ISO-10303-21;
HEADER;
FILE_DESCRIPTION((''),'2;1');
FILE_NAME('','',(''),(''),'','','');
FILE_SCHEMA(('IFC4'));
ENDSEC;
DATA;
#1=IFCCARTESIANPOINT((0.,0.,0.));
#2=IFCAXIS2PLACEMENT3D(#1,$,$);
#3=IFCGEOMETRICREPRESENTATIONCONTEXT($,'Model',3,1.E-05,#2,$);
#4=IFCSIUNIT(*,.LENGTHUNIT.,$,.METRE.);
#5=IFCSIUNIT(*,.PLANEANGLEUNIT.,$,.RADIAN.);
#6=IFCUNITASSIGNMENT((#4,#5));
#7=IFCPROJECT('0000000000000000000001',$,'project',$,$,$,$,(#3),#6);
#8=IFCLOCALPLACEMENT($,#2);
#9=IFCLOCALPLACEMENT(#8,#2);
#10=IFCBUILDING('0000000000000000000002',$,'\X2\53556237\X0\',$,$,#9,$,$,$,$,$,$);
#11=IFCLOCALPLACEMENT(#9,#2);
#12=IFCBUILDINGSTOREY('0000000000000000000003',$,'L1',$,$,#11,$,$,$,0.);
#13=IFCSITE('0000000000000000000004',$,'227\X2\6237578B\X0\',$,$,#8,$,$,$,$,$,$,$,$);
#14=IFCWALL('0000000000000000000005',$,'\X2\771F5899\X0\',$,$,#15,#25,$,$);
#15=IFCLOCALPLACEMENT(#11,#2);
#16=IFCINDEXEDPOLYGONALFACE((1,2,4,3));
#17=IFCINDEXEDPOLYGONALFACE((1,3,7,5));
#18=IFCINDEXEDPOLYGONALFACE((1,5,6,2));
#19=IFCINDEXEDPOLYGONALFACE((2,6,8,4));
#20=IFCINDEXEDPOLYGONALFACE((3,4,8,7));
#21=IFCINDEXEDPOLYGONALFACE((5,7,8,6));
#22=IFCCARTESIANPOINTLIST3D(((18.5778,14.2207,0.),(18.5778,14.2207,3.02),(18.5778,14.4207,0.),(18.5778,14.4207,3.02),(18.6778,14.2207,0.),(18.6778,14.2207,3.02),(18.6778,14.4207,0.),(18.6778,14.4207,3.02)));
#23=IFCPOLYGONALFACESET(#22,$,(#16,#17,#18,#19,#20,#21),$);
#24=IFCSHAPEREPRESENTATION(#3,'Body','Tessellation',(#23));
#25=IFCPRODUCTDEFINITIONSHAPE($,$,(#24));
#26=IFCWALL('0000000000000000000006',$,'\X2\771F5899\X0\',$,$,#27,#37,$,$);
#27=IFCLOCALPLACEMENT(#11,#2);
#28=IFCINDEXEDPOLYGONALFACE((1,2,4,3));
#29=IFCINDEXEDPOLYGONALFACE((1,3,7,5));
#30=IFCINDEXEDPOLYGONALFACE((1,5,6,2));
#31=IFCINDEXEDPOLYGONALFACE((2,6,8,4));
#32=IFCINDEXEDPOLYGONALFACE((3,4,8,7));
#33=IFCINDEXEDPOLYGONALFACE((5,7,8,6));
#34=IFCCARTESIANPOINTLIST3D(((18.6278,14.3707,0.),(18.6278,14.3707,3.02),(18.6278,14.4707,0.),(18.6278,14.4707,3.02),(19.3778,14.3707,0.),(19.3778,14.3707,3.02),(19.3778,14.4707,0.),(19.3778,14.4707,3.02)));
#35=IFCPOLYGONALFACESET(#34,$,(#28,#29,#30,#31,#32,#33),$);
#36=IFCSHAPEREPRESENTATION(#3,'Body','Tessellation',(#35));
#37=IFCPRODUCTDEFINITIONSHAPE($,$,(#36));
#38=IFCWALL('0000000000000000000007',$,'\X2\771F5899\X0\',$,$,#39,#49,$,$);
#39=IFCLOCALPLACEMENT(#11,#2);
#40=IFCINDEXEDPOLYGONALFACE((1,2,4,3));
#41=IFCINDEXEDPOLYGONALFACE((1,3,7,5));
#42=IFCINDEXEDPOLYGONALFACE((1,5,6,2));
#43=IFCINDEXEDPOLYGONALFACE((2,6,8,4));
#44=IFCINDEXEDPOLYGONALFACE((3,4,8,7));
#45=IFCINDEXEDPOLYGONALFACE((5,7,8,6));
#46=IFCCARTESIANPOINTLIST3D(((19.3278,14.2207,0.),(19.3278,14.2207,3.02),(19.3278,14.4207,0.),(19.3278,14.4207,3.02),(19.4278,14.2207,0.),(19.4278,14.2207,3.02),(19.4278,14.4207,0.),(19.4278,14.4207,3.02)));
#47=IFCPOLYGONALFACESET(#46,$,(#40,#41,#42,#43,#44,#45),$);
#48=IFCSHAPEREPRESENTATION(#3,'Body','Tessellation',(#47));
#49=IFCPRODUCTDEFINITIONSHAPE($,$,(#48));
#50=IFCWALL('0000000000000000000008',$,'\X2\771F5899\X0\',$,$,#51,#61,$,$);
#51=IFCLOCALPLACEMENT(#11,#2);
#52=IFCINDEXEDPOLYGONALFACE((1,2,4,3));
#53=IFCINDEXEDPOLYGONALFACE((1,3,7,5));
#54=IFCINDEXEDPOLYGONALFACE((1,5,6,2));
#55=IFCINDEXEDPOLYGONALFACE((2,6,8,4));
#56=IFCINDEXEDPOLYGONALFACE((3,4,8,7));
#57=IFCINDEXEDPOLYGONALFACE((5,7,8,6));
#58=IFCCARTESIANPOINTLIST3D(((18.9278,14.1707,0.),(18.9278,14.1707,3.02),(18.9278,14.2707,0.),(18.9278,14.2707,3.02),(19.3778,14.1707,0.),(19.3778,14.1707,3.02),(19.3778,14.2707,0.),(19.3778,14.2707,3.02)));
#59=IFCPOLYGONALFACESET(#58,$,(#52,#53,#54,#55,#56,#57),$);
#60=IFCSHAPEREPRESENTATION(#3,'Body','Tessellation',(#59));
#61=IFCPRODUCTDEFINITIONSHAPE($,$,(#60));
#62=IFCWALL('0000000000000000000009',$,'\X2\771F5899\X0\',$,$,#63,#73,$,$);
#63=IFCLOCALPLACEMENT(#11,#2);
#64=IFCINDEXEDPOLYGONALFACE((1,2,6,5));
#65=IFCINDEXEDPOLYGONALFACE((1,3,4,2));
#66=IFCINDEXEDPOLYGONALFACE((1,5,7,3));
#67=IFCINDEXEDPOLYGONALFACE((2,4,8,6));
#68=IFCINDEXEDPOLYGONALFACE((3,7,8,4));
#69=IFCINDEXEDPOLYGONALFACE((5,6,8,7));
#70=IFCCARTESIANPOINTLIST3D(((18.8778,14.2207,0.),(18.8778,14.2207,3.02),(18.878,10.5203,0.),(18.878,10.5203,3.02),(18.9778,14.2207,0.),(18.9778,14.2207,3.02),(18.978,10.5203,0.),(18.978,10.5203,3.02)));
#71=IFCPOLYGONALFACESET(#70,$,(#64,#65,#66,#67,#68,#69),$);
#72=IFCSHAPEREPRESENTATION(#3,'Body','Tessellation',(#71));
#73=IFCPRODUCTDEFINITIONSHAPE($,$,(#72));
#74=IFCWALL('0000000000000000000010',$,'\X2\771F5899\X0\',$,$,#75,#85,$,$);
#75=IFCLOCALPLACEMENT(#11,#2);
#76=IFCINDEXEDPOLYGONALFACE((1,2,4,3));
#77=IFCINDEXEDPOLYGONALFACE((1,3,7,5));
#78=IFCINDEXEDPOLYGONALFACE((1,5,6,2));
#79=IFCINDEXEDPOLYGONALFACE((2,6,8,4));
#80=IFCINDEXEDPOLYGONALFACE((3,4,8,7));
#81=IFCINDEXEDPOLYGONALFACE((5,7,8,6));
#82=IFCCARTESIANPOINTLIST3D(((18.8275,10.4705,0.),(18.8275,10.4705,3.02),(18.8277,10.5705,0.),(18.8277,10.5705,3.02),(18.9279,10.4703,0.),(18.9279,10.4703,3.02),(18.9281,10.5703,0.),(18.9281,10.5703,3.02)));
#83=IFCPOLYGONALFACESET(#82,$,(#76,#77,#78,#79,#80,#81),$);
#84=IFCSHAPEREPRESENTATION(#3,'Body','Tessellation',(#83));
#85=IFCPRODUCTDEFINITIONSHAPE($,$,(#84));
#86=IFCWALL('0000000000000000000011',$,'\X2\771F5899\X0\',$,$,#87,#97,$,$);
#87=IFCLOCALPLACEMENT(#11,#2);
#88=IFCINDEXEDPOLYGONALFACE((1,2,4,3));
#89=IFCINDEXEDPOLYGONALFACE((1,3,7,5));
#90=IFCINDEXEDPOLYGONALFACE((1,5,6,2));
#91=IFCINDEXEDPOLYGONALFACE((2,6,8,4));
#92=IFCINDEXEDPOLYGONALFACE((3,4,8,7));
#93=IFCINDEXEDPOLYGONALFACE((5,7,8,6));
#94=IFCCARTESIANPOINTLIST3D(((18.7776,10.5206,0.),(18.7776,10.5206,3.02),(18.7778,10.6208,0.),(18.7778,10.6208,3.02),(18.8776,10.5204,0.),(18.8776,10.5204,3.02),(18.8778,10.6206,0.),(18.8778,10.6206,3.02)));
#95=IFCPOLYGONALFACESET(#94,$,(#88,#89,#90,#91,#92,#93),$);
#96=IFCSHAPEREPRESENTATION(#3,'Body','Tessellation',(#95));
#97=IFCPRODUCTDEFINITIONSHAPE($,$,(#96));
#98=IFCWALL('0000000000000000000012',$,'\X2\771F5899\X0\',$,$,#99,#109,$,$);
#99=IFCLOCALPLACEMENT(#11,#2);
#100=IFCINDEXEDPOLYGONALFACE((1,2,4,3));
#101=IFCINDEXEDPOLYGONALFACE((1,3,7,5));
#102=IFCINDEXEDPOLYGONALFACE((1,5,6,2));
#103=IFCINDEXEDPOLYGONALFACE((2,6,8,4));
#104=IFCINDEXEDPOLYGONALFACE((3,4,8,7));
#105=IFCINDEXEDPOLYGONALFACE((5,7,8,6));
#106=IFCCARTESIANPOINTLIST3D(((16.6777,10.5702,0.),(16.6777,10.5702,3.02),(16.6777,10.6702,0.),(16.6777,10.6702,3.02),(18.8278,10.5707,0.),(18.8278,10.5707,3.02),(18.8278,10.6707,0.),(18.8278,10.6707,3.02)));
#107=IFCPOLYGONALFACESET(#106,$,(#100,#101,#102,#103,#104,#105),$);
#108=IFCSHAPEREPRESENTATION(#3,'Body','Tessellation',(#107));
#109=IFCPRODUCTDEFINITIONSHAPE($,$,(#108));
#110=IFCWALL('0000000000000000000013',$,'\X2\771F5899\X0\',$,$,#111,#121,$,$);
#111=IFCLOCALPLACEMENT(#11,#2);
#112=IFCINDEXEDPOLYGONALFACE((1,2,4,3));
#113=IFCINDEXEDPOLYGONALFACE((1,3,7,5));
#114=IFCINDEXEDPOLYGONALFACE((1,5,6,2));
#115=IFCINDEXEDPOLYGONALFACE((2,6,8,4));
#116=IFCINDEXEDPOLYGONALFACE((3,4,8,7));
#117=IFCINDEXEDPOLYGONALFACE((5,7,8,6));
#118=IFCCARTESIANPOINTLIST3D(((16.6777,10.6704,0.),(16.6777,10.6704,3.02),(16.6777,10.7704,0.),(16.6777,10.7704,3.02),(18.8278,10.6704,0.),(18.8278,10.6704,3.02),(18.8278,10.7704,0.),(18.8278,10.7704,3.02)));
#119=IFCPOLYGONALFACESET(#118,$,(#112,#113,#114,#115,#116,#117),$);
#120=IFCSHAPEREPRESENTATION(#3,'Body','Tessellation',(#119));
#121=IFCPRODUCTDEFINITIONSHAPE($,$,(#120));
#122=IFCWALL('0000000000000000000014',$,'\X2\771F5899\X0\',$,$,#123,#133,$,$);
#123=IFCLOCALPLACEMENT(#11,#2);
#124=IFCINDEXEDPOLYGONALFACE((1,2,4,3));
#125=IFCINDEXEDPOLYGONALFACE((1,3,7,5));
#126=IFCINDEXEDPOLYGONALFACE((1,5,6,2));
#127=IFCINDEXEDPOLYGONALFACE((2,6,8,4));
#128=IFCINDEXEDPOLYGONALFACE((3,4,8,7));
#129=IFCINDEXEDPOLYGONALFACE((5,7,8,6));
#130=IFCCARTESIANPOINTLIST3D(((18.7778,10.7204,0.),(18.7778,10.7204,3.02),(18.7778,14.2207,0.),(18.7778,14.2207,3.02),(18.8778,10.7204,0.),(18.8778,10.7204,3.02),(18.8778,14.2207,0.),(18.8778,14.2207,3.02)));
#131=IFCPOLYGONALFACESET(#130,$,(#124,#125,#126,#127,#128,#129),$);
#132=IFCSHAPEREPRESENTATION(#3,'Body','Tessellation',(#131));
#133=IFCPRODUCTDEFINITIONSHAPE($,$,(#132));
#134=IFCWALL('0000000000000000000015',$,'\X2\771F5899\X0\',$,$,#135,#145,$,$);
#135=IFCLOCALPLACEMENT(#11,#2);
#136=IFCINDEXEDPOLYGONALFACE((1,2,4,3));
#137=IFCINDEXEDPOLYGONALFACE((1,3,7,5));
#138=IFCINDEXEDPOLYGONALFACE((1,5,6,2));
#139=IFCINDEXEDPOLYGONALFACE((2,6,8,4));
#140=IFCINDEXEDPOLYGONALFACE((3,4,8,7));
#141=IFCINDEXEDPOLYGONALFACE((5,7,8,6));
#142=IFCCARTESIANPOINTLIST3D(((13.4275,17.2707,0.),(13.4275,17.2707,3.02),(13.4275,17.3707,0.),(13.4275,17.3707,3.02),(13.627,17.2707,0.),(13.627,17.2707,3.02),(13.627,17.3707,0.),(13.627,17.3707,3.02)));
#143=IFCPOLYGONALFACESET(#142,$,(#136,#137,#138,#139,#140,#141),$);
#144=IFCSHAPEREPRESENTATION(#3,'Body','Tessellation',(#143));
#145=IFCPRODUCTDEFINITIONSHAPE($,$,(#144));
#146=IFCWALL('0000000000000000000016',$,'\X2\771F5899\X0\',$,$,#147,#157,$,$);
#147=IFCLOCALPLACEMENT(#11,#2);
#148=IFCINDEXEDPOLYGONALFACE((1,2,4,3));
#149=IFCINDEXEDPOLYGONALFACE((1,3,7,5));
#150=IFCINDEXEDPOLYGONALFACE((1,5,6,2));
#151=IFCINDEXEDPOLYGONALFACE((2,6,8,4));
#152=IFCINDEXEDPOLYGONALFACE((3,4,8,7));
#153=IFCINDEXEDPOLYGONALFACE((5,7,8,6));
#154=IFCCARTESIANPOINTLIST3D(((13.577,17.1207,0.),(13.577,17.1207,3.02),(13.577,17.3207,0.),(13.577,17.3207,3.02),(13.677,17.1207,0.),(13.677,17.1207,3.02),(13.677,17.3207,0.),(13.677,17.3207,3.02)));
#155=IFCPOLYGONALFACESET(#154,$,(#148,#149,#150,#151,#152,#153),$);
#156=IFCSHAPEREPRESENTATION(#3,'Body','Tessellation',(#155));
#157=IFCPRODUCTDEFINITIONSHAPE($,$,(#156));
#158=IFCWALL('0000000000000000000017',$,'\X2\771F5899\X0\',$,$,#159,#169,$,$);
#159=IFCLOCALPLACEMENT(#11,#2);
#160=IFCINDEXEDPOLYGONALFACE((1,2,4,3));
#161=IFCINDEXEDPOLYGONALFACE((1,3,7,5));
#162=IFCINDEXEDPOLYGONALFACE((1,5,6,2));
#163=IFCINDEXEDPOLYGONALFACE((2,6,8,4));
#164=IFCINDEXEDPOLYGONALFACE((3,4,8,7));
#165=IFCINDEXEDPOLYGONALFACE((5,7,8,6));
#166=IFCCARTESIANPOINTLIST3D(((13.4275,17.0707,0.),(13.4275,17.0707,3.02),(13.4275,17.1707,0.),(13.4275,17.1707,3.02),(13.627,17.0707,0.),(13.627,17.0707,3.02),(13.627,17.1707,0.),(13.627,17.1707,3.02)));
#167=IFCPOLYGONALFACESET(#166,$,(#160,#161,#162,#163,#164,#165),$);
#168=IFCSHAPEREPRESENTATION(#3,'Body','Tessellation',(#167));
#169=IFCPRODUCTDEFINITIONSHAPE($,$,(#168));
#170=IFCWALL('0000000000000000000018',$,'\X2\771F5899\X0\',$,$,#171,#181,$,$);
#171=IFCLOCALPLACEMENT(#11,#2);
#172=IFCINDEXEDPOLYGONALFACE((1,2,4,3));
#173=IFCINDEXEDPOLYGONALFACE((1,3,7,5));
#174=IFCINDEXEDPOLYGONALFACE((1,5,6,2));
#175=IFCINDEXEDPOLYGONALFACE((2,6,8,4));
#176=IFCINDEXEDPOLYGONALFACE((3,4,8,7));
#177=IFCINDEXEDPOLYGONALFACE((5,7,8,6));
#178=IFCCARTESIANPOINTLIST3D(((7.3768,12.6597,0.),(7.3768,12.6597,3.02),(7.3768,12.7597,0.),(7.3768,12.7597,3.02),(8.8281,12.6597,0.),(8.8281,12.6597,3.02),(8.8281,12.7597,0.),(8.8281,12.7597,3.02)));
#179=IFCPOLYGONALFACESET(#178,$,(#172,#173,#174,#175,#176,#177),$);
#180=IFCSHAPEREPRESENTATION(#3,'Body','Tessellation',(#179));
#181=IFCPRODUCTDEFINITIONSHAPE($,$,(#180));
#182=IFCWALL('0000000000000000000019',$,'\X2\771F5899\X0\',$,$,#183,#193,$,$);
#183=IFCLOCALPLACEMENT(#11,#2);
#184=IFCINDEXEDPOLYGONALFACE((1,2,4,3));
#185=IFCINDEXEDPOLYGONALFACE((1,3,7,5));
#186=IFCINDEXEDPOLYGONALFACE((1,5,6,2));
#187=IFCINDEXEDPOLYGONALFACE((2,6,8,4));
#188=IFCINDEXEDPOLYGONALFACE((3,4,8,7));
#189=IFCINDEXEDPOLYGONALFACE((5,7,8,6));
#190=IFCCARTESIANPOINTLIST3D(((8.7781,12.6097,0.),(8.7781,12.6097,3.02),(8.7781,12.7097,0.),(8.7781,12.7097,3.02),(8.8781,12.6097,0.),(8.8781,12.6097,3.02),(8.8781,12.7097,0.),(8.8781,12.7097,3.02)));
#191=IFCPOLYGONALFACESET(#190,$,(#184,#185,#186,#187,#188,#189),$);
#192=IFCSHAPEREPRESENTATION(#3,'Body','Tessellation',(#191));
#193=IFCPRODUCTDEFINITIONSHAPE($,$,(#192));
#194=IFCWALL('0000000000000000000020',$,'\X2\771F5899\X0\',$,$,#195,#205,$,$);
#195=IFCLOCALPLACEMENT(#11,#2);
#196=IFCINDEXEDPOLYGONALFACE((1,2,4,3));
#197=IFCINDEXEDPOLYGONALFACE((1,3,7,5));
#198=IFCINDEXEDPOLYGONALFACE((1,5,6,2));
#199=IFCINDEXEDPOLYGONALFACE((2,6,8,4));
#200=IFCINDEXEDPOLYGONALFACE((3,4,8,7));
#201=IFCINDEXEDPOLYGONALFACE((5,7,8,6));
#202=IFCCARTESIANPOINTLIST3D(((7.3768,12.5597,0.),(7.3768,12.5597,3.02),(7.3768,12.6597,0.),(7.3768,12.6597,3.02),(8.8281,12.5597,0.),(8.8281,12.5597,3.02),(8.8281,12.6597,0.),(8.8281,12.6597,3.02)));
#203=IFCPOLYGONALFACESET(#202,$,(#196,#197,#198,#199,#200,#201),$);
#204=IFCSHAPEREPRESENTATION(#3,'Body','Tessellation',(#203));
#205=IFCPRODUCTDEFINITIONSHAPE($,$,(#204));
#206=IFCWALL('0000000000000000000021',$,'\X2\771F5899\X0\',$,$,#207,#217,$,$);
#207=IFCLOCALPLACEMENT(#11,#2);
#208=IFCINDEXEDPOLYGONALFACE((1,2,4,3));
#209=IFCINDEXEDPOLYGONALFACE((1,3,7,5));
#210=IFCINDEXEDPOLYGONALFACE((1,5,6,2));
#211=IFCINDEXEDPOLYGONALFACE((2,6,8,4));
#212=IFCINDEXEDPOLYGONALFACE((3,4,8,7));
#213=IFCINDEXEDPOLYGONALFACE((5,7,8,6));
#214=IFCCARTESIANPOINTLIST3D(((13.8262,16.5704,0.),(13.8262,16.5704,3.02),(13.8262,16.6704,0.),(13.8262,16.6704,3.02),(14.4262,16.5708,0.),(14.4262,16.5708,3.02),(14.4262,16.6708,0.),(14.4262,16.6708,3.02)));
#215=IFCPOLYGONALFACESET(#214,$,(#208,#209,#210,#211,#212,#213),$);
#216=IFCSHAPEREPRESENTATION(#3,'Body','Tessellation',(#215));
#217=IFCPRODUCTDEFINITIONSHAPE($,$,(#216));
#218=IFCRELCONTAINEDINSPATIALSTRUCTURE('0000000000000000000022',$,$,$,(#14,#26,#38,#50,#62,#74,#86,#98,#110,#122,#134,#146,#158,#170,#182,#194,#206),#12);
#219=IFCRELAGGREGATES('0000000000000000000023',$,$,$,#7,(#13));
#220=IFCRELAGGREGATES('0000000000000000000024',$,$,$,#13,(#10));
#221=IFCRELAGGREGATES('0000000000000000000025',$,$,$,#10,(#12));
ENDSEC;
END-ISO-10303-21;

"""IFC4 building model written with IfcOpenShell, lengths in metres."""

from ifc_helpers import new_model, si_unit, origin, place, context, project, spatial, polyline, outline, extrude, element, save


model = new_model("IFC4")

# Units and contexts
model_context = context("Model", 3, precision=1e-05, world=origin())
ifc_project = project(units=[si_unit("LENGTHUNIT", "METRE"), si_unit("PLANEANGLEUNIT", "RADIAN")], contexts=[model_context])

# Site, building, storey
site_placement = place(None, origin())
site = spatial("IfcSite", under=ifc_project, at=site_placement, Name="227户型")
building_placement = place(site_placement, origin())
building = spatial("IfcBuilding", under=site, at=building_placement, Name="单户")
storey_placement = place(building_placement, origin())
storey = spatial("IfcBuildingStorey", under=building, at=storey_placement, Name="L1", Elevation=0.0)

# Walls
wall_1_placement = place(storey_placement, origin())
element("IfcWall", 1, at=wall_1_placement, inside=storey, Name="真墙", context=model_context, shape_type="SweptSolid", body=[
    extrude(outline(polyline([(18.5778, 14.2207), (18.5778, 14.4207), (18.6778, 14.4207), (18.6778, 14.2207), (18.5778, 14.2207)])), origin(), (0.0, 0.0, 1.0), 3.02),
])
wall_2_placement = place(storey_placement, origin())
element("IfcWall", 2, at=wall_2_placement, inside=storey, Name="真墙", context=model_context, shape_type="SweptSolid", body=[
    extrude(outline(polyline([(18.6278, 14.4707), (19.3778, 14.4707), (19.3778, 14.3707), (18.6278, 14.3707), (18.6278, 14.4707)])), origin(), (0.0, 0.0, 1.0), 3.02),
])
wall_3_placement = place(storey_placement, origin())
element("IfcWall", 3, at=wall_3_placement, inside=storey, Name="真墙", context=model_context, shape_type="SweptSolid", body=[
    extrude(outline(polyline([(19.4278, 14.4207), (19.4278, 14.2207), (19.3278, 14.2207), (19.3278, 14.4207), (19.4278, 14.4207)])), origin(), (0.0, 0.0, 1.0), 3.02),
])
wall_4_placement = place(storey_placement, origin())
element("IfcWall", 4, at=wall_4_placement, inside=storey, Name="真墙", context=model_context, shape_type="SweptSolid", body=[
    extrude(outline(polyline([(19.3778, 14.1707), (18.9278, 14.1707), (18.9278, 14.2707), (19.3778, 14.2707), (19.3778, 14.1707)])), origin(), (0.0, 0.0, 1.0), 3.02),
])
wall_5_placement = place(storey_placement, origin())
element("IfcWall", 5, at=wall_5_placement, inside=storey, Name="真墙", context=model_context, shape_type="SweptSolid", body=[
    extrude(outline(polyline([(18.9778, 14.2207), (18.978, 10.5203), (18.878, 10.5203), (18.8778, 14.2207), (18.9778, 14.2207)])), origin(), (0.0, 0.0, 1.0), 3.02),
])
wall_6_placement = place(storey_placement, origin())
element("IfcWall", 6, at=wall_6_placement, inside=storey, Name="真墙", context=model_context, shape_type="SweptSolid", body=[
    extrude(outline(polyline([(18.9279, 10.4703), (18.8275, 10.4705), (18.8277, 10.5705), (18.9281, 10.5703), (18.9279, 10.4703)])), origin(), (0.0, 0.0, 1.0), 3.02),
])
wall_7_placement = place(storey_placement, origin())
element("IfcWall", 7, at=wall_7_placement, inside=storey, Name="真墙", context=model_context, shape_type="SweptSolid", body=[
    extrude(outline(polyline([(18.7776, 10.5206), (18.7778, 10.6208), (18.8778, 10.6206), (18.8776, 10.5204), (18.7776, 10.5206)])), origin(), (0.0, 0.0, 1.0), 3.02),
])
wall_8_placement = place(storey_placement, origin())
element("IfcWall", 8, at=wall_8_placement, inside=storey, Name="真墙", context=model_context, shape_type="SweptSolid", body=[
    extrude(outline(polyline([(18.8278, 10.5707), (16.6777, 10.5702), (16.6777, 10.6702), (18.8278, 10.6707), (18.8278, 10.5707)])), origin(), (0.0, 0.0, 1.0), 3.02),
])

# Walls
wall_9_placement = place(storey_placement, origin())
element("IfcWall", 9, at=wall_9_placement, inside=storey, Name="真墙", context=model_context, shape_type="SweptSolid", body=[
    extrude(outline(polyline([(16.6777, 10.7704), (18.8278, 10.7704), (18.8278, 10.6704), (16.6777, 10.6704), (16.6777, 10.7704)])), origin(), (0.0, 0.0, 1.0), 3.02),
])
wall_10_placement = place(storey_placement, origin())
element("IfcWall", 10, at=wall_10_placement, inside=storey, Name="真墙", context=model_context, shape_type="SweptSolid", body=[
    extrude(outline(polyline([(18.7778, 10.7204), (18.7778, 14.2207), (18.8778, 14.2207), (18.8778, 10.7204), (18.7778, 10.7204)])), origin(), (0.0, 0.0, 1.0), 3.02),
])
wall_11_placement = place(storey_placement, origin())
element("IfcWall", 11, at=wall_11_placement, inside=storey, Name="真墙", context=model_context, shape_type="SweptSolid", body=[
    extrude(outline(polyline([(13.4275, 17.3707), (13.627, 17.3707), (13.627, 17.2707), (13.4275, 17.2707), (13.4275, 17.3707)])), origin(), (0.0, 0.0, 1.0), 3.02),
])
wall_12_placement = place(storey_placement, origin())
element("IfcWall", 12, at=wall_12_placement, inside=storey, Name="真墙", context=model_context, shape_type="SweptSolid", body=[
    extrude(outline(polyline([(13.677, 17.3207), (13.677, 17.1207), (13.577, 17.1207), (13.577, 17.3207), (13.677, 17.3207)])), origin(), (0.0, 0.0, 1.0), 3.02),
])
wall_13_placement = place(storey_placement, origin())
element("IfcWall", 13, at=wall_13_placement, inside=storey, Name="真墙", context=model_context, shape_type="SweptSolid", body=[
    extrude(outline(polyline([(13.627, 17.0707), (13.4275, 17.0707), (13.4275, 17.1707), (13.627, 17.1707), (13.627, 17.0707)])), origin(), (0.0, 0.0, 1.0), 3.02),
])
wall_14_placement = place(storey_placement, origin())
element("IfcWall", 14, at=wall_14_placement, inside=storey, Name="真墙", context=model_context, shape_type="SweptSolid", body=[
    extrude(outline(polyline([(7.3768, 12.7597), (8.8281, 12.7597), (8.8281, 12.6597), (7.3768, 12.6597), (7.3768, 12.7597)])), origin(), (0.0, 0.0, 1.0), 3.02),
])
wall_15_placement = place(storey_placement, origin())
element("IfcWall", 15, at=wall_15_placement, inside=storey, Name="真墙", context=model_context, shape_type="SweptSolid", body=[
    extrude(outline(polyline([(8.8781, 12.7097), (8.8781, 12.6097), (8.7781, 12.6097), (8.7781, 12.7097), (8.8781, 12.7097)])), origin(), (0.0, 0.0, 1.0), 3.02),
])
wall_16_placement = place(storey_placement, origin())
element("IfcWall", 16, at=wall_16_placement, inside=storey, Name="真墙", context=model_context, shape_type="SweptSolid", body=[
    extrude(outline(polyline([(8.8281, 12.5597), (7.3768, 12.5597), (7.3768, 12.6597), (8.8281, 12.6597), (8.8281, 12.5597)])), origin(), (0.0, 0.0, 1.0), 3.02),
])
wall_17_placement = place(storey_placement, origin())
element("IfcWall", 17, at=wall_17_placement, inside=storey, Name="真墙", context=model_context, shape_type="SweptSolid", body=[
    extrude(outline(polyline([(14.4262, 16.5708), (13.8262, 16.5704), (13.8262, 16.6704), (14.4262, 16.6708), (14.4262, 16.5708)])), origin(), (0.0, 0.0, 1.0), 3.02),
])

save(model, "model.ifc")
